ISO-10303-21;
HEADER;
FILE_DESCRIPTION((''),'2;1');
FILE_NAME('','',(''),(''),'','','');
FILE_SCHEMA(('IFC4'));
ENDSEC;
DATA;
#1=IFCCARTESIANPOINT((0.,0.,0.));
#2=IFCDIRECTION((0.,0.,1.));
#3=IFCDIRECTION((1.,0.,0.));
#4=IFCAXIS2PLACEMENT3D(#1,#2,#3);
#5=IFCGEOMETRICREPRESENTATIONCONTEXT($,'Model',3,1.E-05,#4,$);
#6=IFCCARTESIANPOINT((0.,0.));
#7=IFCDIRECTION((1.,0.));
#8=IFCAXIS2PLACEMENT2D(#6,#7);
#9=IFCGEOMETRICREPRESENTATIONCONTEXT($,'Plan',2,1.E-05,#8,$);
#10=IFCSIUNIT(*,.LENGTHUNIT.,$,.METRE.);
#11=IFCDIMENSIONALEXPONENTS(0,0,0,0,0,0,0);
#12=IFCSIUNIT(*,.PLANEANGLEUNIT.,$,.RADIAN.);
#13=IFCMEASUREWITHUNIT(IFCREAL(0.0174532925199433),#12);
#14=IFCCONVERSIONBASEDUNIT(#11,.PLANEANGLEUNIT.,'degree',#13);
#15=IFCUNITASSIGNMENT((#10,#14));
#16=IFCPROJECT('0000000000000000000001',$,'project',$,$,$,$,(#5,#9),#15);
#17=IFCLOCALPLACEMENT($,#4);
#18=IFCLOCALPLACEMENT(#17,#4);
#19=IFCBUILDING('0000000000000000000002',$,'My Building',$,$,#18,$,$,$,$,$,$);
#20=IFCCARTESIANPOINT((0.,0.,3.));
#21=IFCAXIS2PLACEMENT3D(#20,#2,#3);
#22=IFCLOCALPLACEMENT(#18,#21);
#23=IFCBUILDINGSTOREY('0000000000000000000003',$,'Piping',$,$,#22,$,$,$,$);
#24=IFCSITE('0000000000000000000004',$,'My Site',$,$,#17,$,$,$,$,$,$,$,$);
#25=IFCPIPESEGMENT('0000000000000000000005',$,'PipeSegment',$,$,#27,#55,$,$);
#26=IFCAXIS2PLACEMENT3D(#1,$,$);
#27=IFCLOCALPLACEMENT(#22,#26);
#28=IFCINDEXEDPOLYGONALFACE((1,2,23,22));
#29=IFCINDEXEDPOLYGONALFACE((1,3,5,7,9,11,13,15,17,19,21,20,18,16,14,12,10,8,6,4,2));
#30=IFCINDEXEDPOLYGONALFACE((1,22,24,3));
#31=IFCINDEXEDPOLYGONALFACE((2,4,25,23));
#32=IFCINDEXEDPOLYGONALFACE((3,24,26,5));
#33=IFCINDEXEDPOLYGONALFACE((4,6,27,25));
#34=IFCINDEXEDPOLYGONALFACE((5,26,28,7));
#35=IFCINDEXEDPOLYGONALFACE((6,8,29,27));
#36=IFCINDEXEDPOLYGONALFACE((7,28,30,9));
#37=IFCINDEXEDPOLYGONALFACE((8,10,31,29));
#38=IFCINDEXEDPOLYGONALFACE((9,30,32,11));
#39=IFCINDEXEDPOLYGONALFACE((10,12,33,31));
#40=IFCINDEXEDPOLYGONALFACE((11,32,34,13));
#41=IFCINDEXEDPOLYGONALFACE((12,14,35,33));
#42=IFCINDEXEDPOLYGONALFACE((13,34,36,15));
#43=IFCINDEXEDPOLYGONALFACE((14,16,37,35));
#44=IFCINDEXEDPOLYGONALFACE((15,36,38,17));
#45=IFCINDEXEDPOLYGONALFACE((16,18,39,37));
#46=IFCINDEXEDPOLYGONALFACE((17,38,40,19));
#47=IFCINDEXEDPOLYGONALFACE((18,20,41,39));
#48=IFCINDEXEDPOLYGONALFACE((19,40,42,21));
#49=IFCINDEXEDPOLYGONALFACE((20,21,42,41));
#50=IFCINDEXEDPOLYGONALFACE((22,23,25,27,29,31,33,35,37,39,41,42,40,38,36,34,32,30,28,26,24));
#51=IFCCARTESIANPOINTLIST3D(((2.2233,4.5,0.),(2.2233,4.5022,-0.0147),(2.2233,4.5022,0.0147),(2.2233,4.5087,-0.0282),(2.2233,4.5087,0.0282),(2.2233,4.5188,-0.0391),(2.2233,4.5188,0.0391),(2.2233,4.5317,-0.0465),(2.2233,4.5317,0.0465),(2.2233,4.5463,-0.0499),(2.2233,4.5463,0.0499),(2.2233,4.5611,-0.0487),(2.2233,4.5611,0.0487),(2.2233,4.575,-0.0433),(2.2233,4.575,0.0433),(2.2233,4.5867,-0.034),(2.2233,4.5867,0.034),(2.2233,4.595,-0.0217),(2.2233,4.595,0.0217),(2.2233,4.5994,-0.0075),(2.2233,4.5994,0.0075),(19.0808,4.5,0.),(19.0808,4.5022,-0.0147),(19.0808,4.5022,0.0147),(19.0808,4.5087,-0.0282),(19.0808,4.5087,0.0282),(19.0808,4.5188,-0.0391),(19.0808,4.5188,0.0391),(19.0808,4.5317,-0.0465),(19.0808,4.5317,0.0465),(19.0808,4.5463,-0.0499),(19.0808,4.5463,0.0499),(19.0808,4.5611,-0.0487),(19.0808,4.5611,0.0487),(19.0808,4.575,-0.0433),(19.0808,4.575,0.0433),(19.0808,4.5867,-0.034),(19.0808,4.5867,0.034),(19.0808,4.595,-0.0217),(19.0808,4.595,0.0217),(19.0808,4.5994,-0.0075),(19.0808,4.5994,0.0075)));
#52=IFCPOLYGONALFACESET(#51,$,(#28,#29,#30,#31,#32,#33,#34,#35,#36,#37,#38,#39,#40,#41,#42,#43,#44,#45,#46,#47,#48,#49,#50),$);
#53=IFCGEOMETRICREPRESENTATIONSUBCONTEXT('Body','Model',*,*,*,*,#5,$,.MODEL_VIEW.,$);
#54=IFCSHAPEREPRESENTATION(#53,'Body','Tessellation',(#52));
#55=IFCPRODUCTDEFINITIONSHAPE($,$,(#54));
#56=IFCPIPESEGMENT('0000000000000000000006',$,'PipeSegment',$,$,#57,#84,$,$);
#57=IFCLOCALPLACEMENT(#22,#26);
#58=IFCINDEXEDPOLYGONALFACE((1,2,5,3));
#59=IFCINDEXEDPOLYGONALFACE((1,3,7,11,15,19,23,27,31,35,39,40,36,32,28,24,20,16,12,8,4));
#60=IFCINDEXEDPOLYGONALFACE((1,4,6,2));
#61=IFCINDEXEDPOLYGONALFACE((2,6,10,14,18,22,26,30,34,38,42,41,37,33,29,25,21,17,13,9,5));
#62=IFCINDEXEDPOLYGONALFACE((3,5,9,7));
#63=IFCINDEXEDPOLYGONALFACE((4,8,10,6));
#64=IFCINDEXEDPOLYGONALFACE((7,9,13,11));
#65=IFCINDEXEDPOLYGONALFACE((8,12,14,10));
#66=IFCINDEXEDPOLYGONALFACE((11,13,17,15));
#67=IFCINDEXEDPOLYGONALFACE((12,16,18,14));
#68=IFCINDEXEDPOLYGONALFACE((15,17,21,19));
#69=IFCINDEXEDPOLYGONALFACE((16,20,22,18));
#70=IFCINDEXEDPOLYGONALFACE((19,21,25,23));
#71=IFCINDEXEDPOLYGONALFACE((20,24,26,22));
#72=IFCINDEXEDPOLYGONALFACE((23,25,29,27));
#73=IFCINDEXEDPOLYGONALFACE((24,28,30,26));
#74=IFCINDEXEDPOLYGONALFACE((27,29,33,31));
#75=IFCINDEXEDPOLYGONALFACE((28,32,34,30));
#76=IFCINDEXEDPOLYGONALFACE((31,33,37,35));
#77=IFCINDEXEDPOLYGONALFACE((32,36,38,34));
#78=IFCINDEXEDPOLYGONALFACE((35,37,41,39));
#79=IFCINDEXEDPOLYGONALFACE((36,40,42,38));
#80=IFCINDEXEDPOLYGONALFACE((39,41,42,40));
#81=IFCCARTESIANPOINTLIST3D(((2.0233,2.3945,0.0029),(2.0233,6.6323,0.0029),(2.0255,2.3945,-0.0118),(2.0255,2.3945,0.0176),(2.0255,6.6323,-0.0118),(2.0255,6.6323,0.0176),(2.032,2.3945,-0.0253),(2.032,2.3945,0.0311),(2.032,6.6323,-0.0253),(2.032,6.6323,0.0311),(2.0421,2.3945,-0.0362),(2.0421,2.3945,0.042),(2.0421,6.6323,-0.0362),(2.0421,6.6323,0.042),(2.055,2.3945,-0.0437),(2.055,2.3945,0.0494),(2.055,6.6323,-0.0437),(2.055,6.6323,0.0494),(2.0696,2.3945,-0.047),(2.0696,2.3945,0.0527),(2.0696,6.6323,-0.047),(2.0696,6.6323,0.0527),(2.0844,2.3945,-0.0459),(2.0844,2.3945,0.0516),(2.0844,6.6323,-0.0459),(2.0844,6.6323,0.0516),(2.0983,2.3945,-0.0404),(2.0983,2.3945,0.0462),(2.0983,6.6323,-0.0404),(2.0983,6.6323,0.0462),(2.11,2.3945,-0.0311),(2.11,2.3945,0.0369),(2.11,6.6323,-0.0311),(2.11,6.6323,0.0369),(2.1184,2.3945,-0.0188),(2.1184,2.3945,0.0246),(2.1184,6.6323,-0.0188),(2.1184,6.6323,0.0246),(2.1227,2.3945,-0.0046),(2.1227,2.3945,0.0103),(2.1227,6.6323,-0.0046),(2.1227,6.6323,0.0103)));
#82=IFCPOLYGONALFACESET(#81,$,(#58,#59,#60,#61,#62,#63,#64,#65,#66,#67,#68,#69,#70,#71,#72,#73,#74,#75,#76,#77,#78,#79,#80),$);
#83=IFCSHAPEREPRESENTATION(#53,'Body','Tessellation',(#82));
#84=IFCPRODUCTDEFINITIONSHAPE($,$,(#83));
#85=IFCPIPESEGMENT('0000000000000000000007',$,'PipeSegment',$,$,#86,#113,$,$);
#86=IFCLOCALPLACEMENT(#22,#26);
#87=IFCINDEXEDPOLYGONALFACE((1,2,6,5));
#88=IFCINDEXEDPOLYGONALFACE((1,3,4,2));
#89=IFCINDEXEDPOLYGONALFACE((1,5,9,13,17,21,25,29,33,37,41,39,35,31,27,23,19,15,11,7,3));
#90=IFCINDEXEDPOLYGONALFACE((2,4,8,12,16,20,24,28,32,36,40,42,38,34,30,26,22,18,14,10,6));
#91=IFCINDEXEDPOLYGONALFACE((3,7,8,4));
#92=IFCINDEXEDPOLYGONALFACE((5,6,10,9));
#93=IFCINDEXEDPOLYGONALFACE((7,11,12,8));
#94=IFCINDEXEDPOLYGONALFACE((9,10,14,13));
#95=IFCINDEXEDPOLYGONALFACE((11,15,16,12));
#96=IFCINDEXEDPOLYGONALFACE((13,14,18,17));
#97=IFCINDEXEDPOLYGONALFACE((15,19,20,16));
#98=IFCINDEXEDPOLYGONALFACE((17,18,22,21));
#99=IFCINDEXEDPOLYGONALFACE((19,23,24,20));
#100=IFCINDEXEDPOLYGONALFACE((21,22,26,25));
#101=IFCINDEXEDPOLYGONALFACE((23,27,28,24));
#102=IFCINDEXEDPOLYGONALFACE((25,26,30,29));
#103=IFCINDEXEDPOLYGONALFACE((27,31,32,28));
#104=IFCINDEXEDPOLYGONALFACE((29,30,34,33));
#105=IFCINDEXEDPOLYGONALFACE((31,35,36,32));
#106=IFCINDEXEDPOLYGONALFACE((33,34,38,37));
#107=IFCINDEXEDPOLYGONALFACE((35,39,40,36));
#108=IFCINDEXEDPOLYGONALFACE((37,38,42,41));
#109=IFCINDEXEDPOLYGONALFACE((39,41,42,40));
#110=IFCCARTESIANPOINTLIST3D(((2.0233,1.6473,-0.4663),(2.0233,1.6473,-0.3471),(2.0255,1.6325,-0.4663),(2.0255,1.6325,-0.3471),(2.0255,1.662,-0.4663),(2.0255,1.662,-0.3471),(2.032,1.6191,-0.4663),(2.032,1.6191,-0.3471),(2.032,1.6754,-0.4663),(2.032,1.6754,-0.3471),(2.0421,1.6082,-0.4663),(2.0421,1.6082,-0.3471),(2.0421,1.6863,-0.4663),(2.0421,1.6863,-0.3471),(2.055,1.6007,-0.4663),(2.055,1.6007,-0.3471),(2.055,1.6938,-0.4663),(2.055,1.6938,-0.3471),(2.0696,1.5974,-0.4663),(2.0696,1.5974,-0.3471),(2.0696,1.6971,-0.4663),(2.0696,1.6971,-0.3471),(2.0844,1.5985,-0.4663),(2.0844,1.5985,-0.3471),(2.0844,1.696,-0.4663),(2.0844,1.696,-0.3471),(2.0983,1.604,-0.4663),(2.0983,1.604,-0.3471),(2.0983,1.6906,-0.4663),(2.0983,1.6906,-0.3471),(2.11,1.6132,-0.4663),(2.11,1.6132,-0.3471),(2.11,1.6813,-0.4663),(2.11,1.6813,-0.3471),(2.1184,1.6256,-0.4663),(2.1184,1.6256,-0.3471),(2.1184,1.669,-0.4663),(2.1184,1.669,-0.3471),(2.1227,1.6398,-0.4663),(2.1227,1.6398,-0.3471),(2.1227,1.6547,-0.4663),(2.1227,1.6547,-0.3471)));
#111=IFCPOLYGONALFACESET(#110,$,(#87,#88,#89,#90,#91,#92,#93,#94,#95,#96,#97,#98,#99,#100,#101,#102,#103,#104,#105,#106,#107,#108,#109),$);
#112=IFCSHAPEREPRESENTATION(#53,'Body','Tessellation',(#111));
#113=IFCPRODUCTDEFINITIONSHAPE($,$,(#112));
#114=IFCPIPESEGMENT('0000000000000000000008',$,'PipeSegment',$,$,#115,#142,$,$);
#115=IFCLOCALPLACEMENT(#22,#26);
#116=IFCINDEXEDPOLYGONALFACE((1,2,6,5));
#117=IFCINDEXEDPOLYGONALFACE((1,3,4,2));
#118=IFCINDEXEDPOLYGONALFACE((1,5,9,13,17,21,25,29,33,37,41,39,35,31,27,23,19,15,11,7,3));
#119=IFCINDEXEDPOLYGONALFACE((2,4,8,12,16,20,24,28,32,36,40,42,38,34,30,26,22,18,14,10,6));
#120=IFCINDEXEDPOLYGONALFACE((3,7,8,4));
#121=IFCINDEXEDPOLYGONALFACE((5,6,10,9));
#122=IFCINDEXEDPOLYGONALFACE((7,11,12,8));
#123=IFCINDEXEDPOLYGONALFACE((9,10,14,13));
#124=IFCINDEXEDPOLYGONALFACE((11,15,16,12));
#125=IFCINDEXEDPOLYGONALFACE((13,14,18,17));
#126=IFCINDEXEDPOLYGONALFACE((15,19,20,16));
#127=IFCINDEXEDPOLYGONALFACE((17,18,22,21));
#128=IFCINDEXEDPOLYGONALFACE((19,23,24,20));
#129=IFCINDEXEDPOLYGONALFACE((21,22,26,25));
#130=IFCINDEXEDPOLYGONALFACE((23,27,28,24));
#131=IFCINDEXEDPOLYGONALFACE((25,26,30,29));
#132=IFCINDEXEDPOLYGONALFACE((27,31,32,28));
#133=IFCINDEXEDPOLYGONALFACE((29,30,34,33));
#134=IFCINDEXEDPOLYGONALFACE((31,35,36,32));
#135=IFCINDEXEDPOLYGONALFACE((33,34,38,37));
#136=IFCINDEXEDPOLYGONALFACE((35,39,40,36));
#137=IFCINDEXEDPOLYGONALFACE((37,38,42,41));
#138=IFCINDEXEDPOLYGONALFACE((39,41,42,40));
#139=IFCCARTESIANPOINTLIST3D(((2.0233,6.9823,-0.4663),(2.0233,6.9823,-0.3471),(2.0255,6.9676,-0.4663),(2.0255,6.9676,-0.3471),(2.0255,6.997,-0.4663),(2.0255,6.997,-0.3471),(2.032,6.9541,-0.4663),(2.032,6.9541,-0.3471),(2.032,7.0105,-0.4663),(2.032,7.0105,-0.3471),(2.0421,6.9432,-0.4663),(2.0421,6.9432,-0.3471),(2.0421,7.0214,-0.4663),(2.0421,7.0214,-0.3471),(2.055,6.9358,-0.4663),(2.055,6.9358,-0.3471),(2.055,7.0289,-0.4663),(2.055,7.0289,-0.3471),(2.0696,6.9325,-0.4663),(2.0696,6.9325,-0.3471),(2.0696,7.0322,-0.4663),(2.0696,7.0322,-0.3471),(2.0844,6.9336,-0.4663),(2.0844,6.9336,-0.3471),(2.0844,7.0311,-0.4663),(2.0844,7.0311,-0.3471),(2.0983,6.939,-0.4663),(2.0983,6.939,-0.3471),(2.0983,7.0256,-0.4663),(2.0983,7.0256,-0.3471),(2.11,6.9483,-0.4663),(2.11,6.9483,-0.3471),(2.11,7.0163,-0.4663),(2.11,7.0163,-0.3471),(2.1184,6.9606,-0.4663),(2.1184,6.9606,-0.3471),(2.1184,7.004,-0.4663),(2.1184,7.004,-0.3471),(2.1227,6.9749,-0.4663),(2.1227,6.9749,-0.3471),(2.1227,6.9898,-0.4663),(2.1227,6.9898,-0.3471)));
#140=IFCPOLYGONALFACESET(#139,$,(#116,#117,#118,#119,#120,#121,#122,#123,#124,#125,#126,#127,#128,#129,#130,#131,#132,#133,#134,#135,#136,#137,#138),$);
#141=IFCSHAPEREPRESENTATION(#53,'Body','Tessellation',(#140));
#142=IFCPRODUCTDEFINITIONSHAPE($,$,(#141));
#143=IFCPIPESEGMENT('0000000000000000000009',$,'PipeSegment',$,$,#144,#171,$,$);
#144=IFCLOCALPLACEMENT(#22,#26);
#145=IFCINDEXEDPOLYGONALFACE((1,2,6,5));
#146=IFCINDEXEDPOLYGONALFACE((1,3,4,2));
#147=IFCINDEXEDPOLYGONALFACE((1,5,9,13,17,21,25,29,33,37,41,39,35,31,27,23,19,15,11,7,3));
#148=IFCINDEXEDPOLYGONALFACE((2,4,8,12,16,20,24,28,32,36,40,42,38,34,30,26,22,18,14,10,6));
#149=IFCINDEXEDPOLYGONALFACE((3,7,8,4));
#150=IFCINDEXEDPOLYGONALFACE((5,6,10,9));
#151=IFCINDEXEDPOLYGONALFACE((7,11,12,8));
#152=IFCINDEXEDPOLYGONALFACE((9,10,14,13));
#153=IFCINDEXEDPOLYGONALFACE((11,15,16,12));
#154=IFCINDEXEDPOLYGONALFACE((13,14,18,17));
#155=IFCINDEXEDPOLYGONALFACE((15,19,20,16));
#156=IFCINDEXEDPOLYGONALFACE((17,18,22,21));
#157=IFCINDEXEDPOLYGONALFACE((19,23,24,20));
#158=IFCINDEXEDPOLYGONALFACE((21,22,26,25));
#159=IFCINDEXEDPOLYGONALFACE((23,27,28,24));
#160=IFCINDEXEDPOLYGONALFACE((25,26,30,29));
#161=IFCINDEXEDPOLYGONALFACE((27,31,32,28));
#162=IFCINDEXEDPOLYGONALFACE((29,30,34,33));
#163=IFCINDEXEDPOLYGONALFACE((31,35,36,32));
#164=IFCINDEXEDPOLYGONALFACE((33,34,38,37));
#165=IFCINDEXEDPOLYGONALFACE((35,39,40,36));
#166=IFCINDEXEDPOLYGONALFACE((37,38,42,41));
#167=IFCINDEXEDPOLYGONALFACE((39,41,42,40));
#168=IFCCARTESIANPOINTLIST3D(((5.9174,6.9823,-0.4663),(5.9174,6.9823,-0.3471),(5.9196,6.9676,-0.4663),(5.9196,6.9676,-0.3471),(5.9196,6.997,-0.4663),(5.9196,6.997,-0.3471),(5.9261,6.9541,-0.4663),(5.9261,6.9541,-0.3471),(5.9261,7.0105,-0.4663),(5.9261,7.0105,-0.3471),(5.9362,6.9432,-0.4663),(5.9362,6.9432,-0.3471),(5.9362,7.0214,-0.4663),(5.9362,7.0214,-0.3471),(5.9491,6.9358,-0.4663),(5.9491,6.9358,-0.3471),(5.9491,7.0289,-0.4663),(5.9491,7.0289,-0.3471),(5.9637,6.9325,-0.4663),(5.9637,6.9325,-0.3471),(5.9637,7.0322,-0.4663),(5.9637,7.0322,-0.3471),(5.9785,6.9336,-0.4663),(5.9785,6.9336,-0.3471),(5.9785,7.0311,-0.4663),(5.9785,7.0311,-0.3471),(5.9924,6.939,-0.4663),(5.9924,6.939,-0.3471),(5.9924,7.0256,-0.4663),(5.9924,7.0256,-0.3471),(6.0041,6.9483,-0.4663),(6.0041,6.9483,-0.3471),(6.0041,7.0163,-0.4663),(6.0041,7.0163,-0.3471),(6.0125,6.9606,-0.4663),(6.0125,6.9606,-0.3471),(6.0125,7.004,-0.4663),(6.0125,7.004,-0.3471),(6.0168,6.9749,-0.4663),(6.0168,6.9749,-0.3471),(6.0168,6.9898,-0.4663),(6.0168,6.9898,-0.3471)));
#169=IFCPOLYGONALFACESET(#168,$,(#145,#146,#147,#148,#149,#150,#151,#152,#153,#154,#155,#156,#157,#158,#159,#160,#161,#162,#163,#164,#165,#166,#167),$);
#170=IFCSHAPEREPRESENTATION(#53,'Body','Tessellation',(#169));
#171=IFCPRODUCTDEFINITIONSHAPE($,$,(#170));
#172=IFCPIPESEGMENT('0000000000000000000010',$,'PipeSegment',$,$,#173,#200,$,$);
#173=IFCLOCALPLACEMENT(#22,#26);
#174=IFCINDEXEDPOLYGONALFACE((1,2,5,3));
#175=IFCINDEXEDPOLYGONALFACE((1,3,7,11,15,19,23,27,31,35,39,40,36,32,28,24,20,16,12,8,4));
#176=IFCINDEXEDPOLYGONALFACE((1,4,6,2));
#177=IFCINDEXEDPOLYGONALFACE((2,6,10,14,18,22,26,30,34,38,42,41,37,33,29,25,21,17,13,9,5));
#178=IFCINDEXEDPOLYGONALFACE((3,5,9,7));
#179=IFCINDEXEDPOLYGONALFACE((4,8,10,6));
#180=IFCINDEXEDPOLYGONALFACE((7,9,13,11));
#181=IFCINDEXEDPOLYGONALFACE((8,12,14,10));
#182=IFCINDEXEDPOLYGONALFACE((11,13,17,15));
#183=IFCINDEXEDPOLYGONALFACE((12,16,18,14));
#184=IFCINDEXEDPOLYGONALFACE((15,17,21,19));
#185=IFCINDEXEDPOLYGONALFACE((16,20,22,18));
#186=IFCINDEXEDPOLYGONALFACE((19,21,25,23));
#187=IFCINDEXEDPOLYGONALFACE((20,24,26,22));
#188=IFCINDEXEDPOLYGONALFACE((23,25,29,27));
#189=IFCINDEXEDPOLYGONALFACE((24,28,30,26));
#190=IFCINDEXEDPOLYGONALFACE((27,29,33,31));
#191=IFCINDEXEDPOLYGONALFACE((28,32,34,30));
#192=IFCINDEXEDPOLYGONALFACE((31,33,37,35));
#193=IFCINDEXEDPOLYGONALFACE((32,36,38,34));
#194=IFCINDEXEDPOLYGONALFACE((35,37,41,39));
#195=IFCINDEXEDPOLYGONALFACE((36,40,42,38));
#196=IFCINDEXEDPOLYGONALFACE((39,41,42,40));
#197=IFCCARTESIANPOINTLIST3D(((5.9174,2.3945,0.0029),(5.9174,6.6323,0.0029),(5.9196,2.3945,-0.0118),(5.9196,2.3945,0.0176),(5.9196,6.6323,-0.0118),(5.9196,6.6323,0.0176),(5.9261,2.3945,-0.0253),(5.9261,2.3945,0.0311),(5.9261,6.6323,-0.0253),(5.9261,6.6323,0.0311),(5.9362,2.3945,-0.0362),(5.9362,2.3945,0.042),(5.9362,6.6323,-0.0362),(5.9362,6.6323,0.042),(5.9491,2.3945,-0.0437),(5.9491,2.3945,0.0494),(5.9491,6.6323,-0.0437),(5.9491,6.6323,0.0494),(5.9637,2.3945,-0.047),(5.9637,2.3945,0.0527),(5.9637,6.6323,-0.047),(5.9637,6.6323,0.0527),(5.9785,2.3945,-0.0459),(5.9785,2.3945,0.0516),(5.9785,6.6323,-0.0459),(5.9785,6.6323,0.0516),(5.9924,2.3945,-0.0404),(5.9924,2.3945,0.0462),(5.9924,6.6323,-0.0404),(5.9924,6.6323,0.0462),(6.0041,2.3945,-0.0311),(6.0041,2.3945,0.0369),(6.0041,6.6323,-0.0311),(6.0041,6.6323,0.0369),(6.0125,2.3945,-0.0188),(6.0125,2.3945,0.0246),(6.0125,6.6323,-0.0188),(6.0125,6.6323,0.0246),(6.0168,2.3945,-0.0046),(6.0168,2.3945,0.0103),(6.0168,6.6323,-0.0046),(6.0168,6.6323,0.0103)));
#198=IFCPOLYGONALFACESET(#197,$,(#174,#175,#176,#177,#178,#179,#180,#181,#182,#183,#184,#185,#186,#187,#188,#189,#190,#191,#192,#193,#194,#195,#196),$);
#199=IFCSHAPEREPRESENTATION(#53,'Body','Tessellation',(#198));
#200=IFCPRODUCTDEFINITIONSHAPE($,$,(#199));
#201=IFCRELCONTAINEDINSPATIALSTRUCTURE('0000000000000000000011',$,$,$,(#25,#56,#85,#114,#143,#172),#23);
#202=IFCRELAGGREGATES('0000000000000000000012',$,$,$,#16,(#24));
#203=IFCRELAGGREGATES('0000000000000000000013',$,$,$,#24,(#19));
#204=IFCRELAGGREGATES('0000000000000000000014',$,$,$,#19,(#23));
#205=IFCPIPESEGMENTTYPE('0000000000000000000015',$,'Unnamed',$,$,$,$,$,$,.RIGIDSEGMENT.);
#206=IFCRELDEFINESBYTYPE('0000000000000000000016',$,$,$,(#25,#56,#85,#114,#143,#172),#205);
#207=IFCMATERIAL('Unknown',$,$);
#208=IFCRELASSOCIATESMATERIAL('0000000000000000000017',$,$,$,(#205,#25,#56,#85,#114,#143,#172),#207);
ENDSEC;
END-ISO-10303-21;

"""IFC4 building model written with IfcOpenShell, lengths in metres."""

from ifc_helpers import new_model, entity, si_unit, converted_unit, frame, origin_with_axes, origin_2d_with_axis, place, context, subcontext, project, spatial, circle, extrude, material, material_profile, profile_set, profile_usage, type_object, element, save


model = new_model("IFC4")

# Units and contexts
model_context = context("Model", 3, precision=1e-05, world=origin_with_axes())
plan_context = context("Plan", 2, precision=1e-05, world=origin_2d_with_axis())
body_context = subcontext(model_context, "Body", "Model", "MODEL_VIEW")
ifc_project = project(units=[si_unit("LENGTHUNIT", "METRE"), converted_unit("PLANEANGLEUNIT", "degree", entity("IfcReal", 0.0174532925199433), si_unit("PLANEANGLEUNIT", "RADIAN"), dimensions=[0, 0, 0, 0, 0, 0, 0])], contexts=[model_context, plan_context])

# Site, building, storey
site_placement = place(None, origin_with_axes())
site = spatial("IfcSite", under=ifc_project, at=site_placement, Name="My Site")
building_placement = place(site_placement, origin_with_axes())
building = spatial("IfcBuilding", under=site, at=building_placement, Name="My Building")
storey_placement = place(building_placement, frame((0.0, 0.0, 3.0), z_axis=(0.0, 0.0, 1.0), x_axis=(1.0, 0.0, 0.0)))
storey = spatial("IfcBuildingStorey", under=building, at=storey_placement, Name="Piping")

# Pipe segments
ifc_material = material(Name="Unknown")
ifc_material_profile_1 = material_profile(ifc_material, circle(Radius=0.05))
ifc_profile_set_1 = profile_set([ifc_material_profile_1])
ifc_profile_usage_1 = profile_usage(ifc_profile_set_1, cardinal=5)
pipe_segment_type = type_object("IfcPipeSegmentType", Name="Unnamed", PredefinedType="RIGIDSEGMENT", material=ifc_profile_set_1)
pipe_segment_1_placement = place(storey_placement, frame((19.0808, 4.55, 0.0), z_axis=(-1.0, 0.0, 0.0), x_axis=(0.0, -1.0, 0.0)))
element("IfcPipeSegment", 1, at=pipe_segment_1_placement, inside=storey, type_object=pipe_segment_type, material=ifc_profile_usage_1, Name="PipeSegment", context=body_context, shape_type="SweptSolid", body=[
    extrude(circle(Radius=0.05), origin_with_axes(), (0.0, 0.0, 1.0), 16.8575),
])
ifc_profile_usage_2 = profile_usage(ifc_profile_set_1, cardinal=5)
pipe_segment_2_placement = place(storey_placement, frame((2.0733, 2.3945, 0.0029), z_axis=(0.0, 1.0, 0.0), x_axis=(-1.0, 0.0, 0.0)))
element("IfcPipeSegment", 2, at=pipe_segment_2_placement, inside=storey, type_object=pipe_segment_type, material=ifc_profile_usage_2, Name="PipeSegment", context=body_context, shape_type="SweptSolid", body=[
    extrude(circle(Radius=0.05), origin_with_axes(), (0.0, 0.0, 1.0), 4.2379),
])
ifc_profile_usage_3 = profile_usage(ifc_profile_set_1, cardinal=5)
pipe_segment_3_placement = place(storey_placement, frame((2.0733, 1.6473, -0.3471), z_axis=(0.0, 0.0, -1.0), x_axis=(-1.0, 0.0, 0.0)))
element("IfcPipeSegment", 3, at=pipe_segment_3_placement, inside=storey, type_object=pipe_segment_type, material=ifc_profile_usage_3, Name="PipeSegment", context=body_context, shape_type="SweptSolid", body=[
    extrude(circle(Radius=0.05), origin_with_axes(), (0.0, 0.0, 1.0), 0.1192),
])
ifc_profile_usage_4 = profile_usage(ifc_profile_set_1, cardinal=5)
pipe_segment_4_placement = place(storey_placement, frame((2.0733, 6.9823, -0.3471), z_axis=(0.0, 0.0, -1.0), x_axis=(-1.0, 0.0, 0.0)))
element("IfcPipeSegment", 4, at=pipe_segment_4_placement, inside=storey, type_object=pipe_segment_type, material=ifc_profile_usage_4, Name="PipeSegment", context=body_context, shape_type="SweptSolid", body=[
    extrude(circle(Radius=0.05), origin_with_axes(), (0.0, 0.0, 1.0), 0.1192),
])
ifc_profile_usage_5 = profile_usage(ifc_profile_set_1, cardinal=5)
pipe_segment_5_placement = place(storey_placement, frame((5.9674, 6.9823, -0.3471), z_axis=(0.0, 0.0, -1.0), x_axis=(-1.0, 0.0, 0.0)))
element("IfcPipeSegment", 5, at=pipe_segment_5_placement, inside=storey, type_object=pipe_segment_type, material=ifc_profile_usage_5, Name="PipeSegment", context=body_context, shape_type="SweptSolid", body=[
    extrude(circle(Radius=0.05), origin_with_axes(), (0.0, 0.0, 1.0), 0.1192),
])
ifc_profile_usage_6 = profile_usage(ifc_profile_set_1, cardinal=5)
pipe_segment_6_placement = place(storey_placement, frame((5.9674, 2.3945, 0.0029), z_axis=(0.0, 1.0, 0.0), x_axis=(-1.0, 0.0, 0.0)))
element("IfcPipeSegment", 6, at=pipe_segment_6_placement, inside=storey, type_object=pipe_segment_type, material=ifc_profile_usage_6, Name="PipeSegment", context=body_context, shape_type="SweptSolid", body=[
    extrude(circle(Radius=0.05), origin_with_axes(), (0.0, 0.0, 1.0), 4.2379),
])

save(model, "model.ifc")
